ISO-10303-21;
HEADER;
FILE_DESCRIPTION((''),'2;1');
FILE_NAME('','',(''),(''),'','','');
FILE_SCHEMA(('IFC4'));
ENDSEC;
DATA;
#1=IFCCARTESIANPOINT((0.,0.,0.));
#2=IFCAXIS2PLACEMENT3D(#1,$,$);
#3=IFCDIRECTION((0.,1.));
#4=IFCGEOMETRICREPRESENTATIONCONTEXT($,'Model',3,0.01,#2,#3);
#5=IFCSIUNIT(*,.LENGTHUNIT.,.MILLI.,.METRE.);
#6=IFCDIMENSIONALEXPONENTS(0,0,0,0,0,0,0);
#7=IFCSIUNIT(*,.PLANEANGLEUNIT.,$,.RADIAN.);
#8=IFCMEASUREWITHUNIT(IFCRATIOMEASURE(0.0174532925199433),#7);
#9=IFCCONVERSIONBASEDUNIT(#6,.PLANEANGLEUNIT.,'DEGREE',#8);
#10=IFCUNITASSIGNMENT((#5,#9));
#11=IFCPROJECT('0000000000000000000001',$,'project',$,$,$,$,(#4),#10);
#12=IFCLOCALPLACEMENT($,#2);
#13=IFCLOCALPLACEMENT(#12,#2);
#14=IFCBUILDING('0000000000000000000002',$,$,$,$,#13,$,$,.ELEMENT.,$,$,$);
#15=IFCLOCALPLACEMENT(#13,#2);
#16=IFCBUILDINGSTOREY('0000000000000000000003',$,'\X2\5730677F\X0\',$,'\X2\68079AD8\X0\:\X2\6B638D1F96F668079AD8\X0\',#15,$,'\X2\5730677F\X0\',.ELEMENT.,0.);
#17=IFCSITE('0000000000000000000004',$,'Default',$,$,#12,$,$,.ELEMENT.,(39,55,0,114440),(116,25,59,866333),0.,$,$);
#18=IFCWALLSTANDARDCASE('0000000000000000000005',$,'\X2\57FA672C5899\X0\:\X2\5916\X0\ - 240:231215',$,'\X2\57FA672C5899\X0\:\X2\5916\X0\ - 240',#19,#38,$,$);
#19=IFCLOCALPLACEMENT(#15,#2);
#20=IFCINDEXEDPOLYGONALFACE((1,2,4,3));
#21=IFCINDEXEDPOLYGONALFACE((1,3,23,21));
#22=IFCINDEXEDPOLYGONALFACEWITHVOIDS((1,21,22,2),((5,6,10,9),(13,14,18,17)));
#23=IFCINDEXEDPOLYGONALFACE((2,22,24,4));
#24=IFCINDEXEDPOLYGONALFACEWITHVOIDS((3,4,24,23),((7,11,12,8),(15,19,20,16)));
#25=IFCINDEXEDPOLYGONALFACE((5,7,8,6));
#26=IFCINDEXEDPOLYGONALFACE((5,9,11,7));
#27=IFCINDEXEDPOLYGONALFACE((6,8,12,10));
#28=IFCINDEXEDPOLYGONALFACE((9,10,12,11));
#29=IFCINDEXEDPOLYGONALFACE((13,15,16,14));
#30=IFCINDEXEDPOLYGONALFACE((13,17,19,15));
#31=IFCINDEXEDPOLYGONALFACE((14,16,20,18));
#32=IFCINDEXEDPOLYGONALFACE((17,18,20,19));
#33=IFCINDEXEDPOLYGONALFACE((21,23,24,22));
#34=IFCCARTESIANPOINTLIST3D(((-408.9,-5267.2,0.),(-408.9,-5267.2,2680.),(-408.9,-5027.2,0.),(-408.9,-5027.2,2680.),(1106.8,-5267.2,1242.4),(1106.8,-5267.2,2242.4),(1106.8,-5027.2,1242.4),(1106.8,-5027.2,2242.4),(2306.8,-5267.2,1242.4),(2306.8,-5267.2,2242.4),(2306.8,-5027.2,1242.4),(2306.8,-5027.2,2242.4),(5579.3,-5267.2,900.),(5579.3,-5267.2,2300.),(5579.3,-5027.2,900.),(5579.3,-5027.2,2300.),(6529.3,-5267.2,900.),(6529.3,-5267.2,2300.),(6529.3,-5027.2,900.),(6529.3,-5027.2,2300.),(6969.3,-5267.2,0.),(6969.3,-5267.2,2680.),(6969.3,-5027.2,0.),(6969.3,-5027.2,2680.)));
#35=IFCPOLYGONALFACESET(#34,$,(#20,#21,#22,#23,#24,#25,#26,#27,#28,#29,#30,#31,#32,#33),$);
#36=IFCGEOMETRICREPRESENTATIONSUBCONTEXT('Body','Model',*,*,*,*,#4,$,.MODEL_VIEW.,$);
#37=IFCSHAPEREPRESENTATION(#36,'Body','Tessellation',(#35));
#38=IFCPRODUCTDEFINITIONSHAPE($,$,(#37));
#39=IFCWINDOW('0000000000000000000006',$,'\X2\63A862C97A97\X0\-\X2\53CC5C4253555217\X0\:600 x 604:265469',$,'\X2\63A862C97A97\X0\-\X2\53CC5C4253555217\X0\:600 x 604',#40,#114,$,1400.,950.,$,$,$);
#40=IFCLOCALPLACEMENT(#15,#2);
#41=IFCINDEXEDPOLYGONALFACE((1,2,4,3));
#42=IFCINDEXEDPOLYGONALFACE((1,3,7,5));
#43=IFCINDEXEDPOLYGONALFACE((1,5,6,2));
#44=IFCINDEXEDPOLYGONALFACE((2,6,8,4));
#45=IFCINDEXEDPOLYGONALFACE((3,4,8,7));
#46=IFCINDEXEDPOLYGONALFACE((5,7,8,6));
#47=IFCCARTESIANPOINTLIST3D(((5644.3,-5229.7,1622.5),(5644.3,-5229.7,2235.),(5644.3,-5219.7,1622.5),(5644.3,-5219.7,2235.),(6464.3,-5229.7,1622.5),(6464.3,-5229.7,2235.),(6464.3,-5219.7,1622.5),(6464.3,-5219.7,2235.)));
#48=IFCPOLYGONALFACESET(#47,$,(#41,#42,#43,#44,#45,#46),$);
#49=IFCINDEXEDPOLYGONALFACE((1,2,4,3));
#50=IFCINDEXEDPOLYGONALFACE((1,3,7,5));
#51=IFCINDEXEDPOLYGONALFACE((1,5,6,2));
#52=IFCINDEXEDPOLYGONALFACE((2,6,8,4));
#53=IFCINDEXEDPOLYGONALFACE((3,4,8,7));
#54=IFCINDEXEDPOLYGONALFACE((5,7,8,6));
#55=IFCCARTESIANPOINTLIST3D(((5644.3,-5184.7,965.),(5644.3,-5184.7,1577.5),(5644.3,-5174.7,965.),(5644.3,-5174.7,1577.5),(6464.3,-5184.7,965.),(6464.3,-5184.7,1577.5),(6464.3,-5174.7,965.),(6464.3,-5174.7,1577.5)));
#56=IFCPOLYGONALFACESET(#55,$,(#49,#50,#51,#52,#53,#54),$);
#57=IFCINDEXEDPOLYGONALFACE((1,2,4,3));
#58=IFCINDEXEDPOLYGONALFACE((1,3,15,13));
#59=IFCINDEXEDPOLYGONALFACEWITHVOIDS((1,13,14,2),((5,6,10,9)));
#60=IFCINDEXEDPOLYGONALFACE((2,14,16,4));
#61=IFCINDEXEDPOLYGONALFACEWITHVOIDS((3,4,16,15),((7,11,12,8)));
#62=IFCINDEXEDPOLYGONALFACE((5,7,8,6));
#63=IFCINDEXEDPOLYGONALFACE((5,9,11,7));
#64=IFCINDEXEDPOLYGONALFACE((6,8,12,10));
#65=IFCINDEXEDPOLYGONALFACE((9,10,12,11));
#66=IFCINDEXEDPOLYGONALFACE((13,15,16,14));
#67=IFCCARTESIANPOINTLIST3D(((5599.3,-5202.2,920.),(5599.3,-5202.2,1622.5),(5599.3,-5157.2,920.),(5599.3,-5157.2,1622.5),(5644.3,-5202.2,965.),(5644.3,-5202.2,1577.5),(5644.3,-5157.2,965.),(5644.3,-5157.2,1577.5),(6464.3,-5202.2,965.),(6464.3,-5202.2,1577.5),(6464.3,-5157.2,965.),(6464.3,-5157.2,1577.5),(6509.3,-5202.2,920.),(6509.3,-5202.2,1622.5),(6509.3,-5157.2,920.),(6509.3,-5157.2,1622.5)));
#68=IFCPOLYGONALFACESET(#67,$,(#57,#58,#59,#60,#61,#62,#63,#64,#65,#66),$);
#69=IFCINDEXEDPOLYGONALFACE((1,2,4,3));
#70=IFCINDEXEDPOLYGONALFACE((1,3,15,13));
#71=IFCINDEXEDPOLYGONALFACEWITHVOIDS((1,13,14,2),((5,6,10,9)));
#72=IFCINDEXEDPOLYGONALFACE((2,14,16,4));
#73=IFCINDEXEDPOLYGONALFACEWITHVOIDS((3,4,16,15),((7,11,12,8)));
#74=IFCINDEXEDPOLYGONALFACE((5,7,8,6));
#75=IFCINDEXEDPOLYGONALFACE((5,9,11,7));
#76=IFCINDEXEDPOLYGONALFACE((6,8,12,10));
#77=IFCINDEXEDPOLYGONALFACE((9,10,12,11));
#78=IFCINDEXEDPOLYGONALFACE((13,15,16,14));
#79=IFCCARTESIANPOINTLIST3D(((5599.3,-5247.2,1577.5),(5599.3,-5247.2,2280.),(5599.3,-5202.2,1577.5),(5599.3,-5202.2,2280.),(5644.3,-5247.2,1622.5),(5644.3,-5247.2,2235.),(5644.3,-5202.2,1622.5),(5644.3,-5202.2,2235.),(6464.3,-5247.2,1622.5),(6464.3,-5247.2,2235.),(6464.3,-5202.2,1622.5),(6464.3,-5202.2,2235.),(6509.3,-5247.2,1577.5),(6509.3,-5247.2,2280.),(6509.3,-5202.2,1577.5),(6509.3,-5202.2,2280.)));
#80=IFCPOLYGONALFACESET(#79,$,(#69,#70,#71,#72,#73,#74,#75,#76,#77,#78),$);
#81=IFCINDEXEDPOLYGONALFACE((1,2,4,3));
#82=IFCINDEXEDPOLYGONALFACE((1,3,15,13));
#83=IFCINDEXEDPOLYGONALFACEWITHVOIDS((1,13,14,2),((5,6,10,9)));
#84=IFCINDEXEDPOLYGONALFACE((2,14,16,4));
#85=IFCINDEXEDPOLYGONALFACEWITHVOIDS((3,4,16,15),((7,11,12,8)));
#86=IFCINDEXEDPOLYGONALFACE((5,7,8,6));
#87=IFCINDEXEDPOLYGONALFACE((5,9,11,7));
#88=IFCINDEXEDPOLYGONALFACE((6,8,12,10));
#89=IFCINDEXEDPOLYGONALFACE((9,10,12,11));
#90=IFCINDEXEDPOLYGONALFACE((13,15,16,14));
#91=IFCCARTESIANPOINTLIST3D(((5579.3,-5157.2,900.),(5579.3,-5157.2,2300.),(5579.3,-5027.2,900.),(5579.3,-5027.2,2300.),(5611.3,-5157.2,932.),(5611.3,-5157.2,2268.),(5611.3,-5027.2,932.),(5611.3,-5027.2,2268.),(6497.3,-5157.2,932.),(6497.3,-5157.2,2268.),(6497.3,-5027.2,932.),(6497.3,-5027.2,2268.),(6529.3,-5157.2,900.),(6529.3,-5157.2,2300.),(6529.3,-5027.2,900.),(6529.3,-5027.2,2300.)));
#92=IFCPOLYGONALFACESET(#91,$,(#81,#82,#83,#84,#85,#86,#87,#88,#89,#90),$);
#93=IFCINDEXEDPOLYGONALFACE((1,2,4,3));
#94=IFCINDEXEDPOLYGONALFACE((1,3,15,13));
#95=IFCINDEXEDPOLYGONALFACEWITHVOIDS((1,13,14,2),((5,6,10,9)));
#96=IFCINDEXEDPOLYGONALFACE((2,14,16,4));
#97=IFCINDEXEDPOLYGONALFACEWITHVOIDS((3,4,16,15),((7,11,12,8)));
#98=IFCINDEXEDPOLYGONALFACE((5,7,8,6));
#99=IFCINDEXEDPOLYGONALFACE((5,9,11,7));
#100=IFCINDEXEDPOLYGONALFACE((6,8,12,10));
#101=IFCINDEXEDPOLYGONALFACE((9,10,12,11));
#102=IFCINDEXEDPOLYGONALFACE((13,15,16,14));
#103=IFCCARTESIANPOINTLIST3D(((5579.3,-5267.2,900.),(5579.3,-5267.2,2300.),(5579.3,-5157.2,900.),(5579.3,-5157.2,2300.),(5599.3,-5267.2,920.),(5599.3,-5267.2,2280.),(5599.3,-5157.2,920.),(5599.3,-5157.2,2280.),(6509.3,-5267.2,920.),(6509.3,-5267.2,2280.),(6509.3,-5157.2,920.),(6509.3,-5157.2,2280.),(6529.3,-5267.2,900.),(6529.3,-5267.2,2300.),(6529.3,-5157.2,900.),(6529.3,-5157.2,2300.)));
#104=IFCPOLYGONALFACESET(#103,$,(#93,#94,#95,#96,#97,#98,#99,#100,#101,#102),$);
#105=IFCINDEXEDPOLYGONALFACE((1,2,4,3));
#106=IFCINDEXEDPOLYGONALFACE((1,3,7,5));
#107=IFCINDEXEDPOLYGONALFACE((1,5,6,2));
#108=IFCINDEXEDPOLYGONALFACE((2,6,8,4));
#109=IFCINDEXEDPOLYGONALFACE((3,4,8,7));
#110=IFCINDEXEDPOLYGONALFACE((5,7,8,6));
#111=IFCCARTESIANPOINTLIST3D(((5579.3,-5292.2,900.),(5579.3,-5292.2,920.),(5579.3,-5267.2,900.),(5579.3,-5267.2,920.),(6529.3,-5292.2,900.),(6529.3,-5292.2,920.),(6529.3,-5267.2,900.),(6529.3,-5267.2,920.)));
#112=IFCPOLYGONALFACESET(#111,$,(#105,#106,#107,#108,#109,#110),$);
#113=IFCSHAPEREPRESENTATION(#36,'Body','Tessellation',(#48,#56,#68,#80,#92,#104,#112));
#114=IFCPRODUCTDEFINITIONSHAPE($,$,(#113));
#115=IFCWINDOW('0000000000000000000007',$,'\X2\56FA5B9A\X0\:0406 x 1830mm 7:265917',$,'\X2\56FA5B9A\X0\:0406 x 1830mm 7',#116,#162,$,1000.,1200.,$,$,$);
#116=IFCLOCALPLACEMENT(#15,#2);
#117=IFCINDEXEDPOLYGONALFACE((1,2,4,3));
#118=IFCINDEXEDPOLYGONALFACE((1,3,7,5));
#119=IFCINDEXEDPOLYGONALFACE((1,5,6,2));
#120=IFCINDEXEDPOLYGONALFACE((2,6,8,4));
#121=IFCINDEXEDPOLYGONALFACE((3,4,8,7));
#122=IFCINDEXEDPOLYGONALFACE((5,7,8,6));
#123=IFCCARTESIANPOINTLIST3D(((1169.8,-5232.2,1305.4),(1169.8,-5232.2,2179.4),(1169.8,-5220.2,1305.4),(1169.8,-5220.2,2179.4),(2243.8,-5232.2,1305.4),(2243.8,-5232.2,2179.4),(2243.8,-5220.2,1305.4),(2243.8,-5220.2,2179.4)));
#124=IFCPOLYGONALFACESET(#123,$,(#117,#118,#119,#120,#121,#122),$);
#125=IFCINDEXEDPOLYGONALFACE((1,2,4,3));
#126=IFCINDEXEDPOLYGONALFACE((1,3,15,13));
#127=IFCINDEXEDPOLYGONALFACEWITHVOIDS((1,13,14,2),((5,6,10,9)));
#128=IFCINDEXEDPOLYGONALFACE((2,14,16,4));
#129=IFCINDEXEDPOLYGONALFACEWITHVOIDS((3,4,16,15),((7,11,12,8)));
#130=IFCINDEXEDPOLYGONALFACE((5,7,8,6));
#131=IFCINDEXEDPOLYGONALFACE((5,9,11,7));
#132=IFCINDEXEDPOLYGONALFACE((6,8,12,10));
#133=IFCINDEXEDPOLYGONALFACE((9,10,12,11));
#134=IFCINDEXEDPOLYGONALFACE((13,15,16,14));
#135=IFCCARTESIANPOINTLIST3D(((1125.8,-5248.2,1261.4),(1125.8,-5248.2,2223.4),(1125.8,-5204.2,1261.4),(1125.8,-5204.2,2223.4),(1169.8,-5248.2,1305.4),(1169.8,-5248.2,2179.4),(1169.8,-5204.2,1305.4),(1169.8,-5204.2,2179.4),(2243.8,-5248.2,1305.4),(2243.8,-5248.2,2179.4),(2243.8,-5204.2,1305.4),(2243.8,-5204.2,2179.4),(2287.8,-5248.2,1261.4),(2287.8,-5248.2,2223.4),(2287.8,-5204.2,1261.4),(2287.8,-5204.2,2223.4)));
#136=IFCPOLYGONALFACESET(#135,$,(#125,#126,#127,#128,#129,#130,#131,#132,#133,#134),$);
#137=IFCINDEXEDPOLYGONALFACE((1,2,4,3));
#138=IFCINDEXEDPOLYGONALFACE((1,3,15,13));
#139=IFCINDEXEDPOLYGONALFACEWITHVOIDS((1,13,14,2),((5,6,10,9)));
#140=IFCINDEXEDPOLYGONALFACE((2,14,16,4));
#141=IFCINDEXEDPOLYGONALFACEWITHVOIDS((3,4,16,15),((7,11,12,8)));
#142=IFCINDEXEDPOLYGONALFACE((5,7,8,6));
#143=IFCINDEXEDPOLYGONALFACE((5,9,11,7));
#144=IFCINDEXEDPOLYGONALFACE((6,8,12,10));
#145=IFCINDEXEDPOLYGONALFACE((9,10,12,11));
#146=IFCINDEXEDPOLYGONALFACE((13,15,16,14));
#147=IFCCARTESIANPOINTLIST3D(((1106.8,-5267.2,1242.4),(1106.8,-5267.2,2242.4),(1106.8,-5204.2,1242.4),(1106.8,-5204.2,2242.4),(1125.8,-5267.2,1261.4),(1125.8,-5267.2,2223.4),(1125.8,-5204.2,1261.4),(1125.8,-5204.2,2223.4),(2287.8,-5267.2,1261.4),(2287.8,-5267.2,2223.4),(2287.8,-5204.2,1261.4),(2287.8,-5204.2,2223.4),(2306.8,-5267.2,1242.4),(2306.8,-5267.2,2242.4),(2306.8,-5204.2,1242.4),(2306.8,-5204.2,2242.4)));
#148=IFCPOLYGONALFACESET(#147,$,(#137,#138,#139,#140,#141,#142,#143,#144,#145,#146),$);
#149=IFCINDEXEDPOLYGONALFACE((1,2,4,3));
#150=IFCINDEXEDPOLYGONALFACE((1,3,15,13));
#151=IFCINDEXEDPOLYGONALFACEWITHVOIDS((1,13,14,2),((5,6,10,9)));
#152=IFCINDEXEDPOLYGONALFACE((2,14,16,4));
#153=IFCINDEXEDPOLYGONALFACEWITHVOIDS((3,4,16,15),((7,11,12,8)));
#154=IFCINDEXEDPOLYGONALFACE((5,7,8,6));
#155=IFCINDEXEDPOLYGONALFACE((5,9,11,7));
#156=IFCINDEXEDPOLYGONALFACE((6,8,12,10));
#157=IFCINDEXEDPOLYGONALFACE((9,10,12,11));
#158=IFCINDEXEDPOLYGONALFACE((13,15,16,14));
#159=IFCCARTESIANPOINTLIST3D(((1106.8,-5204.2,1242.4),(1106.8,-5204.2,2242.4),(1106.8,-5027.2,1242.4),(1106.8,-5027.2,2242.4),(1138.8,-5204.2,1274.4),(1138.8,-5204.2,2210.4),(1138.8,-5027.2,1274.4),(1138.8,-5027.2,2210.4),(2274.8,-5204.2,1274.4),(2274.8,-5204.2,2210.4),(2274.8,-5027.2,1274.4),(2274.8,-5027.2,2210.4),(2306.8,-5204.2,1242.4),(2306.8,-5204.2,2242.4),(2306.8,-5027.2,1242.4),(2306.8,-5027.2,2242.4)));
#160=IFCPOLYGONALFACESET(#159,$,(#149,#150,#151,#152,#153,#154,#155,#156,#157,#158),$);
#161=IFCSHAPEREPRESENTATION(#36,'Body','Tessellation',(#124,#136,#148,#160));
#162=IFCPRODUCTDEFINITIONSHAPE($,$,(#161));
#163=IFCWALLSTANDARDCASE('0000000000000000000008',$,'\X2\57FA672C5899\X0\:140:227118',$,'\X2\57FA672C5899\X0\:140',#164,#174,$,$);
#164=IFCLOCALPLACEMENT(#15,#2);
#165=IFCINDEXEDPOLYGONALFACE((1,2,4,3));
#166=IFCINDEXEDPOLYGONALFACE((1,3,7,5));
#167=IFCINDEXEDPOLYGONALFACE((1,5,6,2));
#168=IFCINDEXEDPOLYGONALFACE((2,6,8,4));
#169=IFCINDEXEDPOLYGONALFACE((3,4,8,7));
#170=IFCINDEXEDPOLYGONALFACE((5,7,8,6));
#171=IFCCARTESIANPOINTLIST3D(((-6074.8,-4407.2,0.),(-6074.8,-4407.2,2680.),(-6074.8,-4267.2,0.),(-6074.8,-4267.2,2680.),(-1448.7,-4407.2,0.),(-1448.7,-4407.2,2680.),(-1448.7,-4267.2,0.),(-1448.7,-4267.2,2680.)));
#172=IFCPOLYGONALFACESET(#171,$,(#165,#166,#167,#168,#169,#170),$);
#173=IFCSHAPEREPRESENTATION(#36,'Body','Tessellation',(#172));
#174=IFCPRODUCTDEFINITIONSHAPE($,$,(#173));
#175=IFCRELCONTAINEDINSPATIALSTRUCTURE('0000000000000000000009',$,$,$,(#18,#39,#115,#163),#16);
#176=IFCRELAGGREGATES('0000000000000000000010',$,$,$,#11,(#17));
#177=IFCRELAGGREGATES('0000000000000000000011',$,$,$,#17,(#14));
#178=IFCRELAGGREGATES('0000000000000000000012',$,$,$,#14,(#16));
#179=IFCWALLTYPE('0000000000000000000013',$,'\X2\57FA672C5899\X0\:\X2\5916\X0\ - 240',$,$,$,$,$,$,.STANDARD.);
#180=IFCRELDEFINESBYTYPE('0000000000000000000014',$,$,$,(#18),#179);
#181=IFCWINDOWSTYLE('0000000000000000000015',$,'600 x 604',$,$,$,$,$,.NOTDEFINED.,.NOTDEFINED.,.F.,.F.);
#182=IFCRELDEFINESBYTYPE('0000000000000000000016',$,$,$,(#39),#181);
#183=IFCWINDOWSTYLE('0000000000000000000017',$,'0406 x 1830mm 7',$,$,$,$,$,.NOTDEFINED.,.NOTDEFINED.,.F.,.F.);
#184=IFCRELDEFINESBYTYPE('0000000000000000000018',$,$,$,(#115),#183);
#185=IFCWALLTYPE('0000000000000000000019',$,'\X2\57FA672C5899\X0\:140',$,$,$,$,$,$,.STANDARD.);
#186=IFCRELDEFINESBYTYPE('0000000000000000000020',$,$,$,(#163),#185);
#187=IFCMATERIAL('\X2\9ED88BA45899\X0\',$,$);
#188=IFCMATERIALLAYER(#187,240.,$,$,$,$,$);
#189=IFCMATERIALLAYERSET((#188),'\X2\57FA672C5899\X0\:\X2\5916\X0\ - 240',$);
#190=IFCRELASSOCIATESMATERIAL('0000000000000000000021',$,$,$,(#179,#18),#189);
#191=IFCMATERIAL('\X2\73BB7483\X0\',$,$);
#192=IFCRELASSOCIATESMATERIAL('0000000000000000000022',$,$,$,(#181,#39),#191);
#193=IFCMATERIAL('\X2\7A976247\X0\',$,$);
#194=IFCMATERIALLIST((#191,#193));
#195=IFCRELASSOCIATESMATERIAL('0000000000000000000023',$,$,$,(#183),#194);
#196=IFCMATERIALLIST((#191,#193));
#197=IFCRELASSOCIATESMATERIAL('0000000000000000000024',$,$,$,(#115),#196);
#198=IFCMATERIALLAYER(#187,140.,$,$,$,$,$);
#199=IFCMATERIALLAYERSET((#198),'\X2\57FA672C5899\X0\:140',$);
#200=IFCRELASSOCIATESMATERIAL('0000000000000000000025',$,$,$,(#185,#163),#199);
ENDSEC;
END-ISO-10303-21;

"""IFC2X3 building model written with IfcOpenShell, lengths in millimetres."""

from ifc_helpers import new_model, entity, si_unit, converted_unit, direction, frame, frame_2d, origin, origin_2d_with_axis, place, context, subcontext, project, spatial, polyline, rectangle, outline, extrude, source, transform, mapped, material, material_list, layer, layer_set, layer_usage, type_object, type_shapes, element, fill, save


model = new_model("IFC2X3")

# Units and contexts
model_context = context("Model", 3, precision=0.01, world=origin(), true_north=direction((0.0, 1.0)))
body_context = subcontext(model_context, "Body", "Model", "MODEL_VIEW")
ifc_project = project(units=[si_unit("LENGTHUNIT", "METRE", prefix="MILLI"), converted_unit("PLANEANGLEUNIT", "DEGREE", entity("IfcRatioMeasure", 0.0174532925199433), si_unit("PLANEANGLEUNIT", "RADIAN"), dimensions=[0, 0, 0, 0, 0, 0, 0])], contexts=[model_context])

# Site, building, storey
site_placement = place(None, origin())
site = spatial("IfcSite", under=ifc_project, at=site_placement, Name="Default", CompositionType="ELEMENT", RefLatitude=(39, 55, 0, 114440), RefLongitude=(116, 25, 59, 866333), RefElevation=0.0)
building_placement = place(site_placement, origin())
building = spatial("IfcBuilding", under=site, at=building_placement, CompositionType="ELEMENT")
storey_placement = place(building_placement, origin())
storey = spatial("IfcBuildingStorey", under=building, at=storey_placement, Name="地板", ObjectType="标高:正负零标高", LongName="地板", CompositionType="ELEMENT", Elevation=0.0)

# Shared definitions
ifc_material_1 = material(Name="默认墙")

# Shared definitions
ifc_layer_1 = layer(ifc_material_1, 240.0)
ifc_layer_set_1 = layer_set([ifc_layer_1], Name="基本墙:外 - 240")
wall_type_1 = type_object("IfcWallType", Name="基本墙:外 - 240", PredefinedType="STANDARD", material=ifc_layer_set_1)

# Wall, openings, windows
ifc_material_2 = material(Name="玻璃")
window_style_1 = type_object("IfcWindowStyle", Name="600 x 604", ConstructionType="NOTDEFINED", OperationType="NOTDEFINED", ParameterTakesPrecedence=False, Sizeable=False, material=ifc_material_2)
shared_shape_1 = source(origin(), body_context, "Body", "SweptSolid", [
    extrude(rectangle(XDim=10.0, YDim=820.0, at=origin_2d_with_axis()), frame((475.0, 197.5, 722.5), z_axis=(0.0, 0.0, 1.0), x_axis=(0.0, -1.0, 0.0)), (0.0, 0.0, 1.0), 612.5),
    extrude(rectangle(XDim=10.0, YDim=820.0, at=origin_2d_with_axis()), frame((475.0, 152.5, 65.0), z_axis=(0.0, 0.0, 1.0), x_axis=(0.0, -1.0, 0.0)), (0.0, 0.0, 1.0), 612.5),
    extrude(outline(polyline([(-455.0, -351.2), (455.0, -351.2), (455.0, 351.2), (-455.0, 351.2), (-455.0, -351.2)]), holes=[polyline([(-410.0, -306.2), (-410.0, 306.2), (410.0, 306.2), (410.0, -306.2), (-410.0, -306.2)])]), frame((475.0, 130.0, 371.3), z_axis=(0.0, 1.0, 0.0), x_axis=(1.0, 0.0, 0.0)), (0.0, 0.0, 1.0), 45.0),
    extrude(outline(polyline([(-455.0, -351.2), (455.0, -351.2), (455.0, 351.2), (-455.0, 351.2), (-455.0, -351.2)]), holes=[polyline([(-410.0, -306.2), (-410.0, 306.2), (410.0, 306.2), (410.0, -306.2), (-410.0, -306.2)])]), frame((475.0, 175.0, 1028.8), z_axis=(0.0, 1.0, 0.0), x_axis=(1.0, 0.0, 0.0)), (0.0, 0.0, 1.0), 45.0),
    extrude(outline(polyline([(-475.0, -700.0), (475.0, -700.0), (475.0, 700.0), (-475.0, 700.0), (-475.0, -700.0)]), holes=[polyline([(-443.0, -668.0), (-443.0, 668.0), (443.0, 668.0), (443.0, -668.0), (-443.0, -668.0)])]), frame((475.0, 0.0, 700.0), z_axis=(0.0, 1.0, 0.0), x_axis=(1.0, 0.0, 0.0)), (0.0, 0.0, 1.0), 130.0),
    extrude(outline(polyline([(-700.0, -475.0), (700.0, -475.0), (700.0, 475.0), (-700.0, 475.0), (-700.0, -475.0)]), holes=[polyline([(-680.0, -455.0), (-680.0, 455.0), (680.0, 455.0), (680.0, -455.0), (-680.0, -455.0)])]), frame((475.0, 130.0, 700.0), z_axis=(0.0, 1.0, 0.0), x_axis=(0.0, 0.0, -1.0)), (0.0, 0.0, 1.0), 110.0),
    extrude(rectangle(XDim=25.0, YDim=950.0, at=origin_2d_with_axis()), frame((475.0, 252.5, 0.0), z_axis=(0.0, 0.0, 1.0), x_axis=(0.0, -1.0, 0.0)), (0.0, 0.0, 1.0), 20.0),
])
type_shapes(window_style_1, [shared_shape_1])
ifc_layer_usage_1 = layer_usage(ifc_layer_set_1, "AXIS2", "NEGATIVE", 120.0)
wall_1_placement = place(storey_placement, frame((-408.9, -5147.2, 0.0)))
wall_1 = element("IfcWallStandardCase", 1, at=wall_1_placement, inside=storey, type_object=wall_type_1, material=ifc_layer_usage_1, Name="基本墙:外 - 240:231215", ObjectType="基本墙:外 - 240", context=body_context, shape_type="SweptSolid", body=[
    extrude(rectangle(XDim=7378.2, YDim=240.0, at=frame_2d((3689.1, 0.0), x_axis=(-1.0, 0.0))), origin(), (0.0, 0.0, 1.0), 2680.0),
])
opening_1_placement = place(wall_1_placement, frame((6938.2, 120.0, 900.0)))
opening_1 = element("IfcOpeningElement", 2, at=opening_1_placement, cuts=wall_1, ObjectType="Opening", context=body_context, shape_type="SweptSolid", body=[
    extrude(rectangle(XDim=1400.0, YDim=950.0, at=frame_2d((700.0, 475.0), x_axis=(-1.0, 0.0))), frame((0.0, 0.0, 0.0), z_axis=(0.0, -1.0, 0.0), x_axis=(0.0, 0.0, 1.0)), (0.0, 0.0, 1.0), 240.0),
])
opening_2_placement = place(wall_1_placement, frame((2715.8, 120.0, 1242.4)))
opening_2 = element("IfcOpeningElement", 3, at=opening_2_placement, cuts=wall_1, ObjectType="Opening", context=body_context, shape_type="SweptSolid", body=[
    extrude(rectangle(XDim=1000.0, YDim=1200.0, at=frame_2d((500.0, 600.0), x_axis=(1.0, 0.0))), frame((0.0, 0.0, 0.0), z_axis=(0.0, -1.0, 0.0), x_axis=(0.0, 0.0, 1.0)), (0.0, 0.0, 1.0), 240.0),
])
window_1_placement = place(opening_1_placement, frame((0.0, 0.0, 0.0), z_axis=(0.0, 0.0, 1.0), x_axis=(-1.0, 0.0, 0.0)))
window_1 = element("IfcWindow", 4, at=window_1_placement, inside=storey, type_object=window_style_1, material=ifc_material_2, Name="推拉窗-双层单列:600 x 604:265469", ObjectType="推拉窗-双层单列:600 x 604", OverallHeight=1400.0, OverallWidth=950.0, context=body_context, shape_type="MappedRepresentation", body=[
    mapped(shared_shape_1, transform((0.0, 0.0, 0.0), scale=1.0)),
])
fill(opening_1, window_1)
ifc_material_3 = material(Name="窗扇")
ifc_material_list_1 = material_list([ifc_material_2, ifc_material_3])
ifc_material_list_2 = material_list([ifc_material_2, ifc_material_3])
window_style_2 = type_object("IfcWindowStyle", Name="0406 x 1830mm 7", ConstructionType="NOTDEFINED", OperationType="NOTDEFINED", ParameterTakesPrecedence=False, Sizeable=False, material=ifc_material_list_2)
shared_shape_2 = source(origin(), body_context, "Body", "SweptSolid", [
    extrude(rectangle(XDim=12.0, YDim=1074.0, at=frame_2d((0.0, 0.0), x_axis=(1.0, 0.0))), frame((600.0, 199.0, 63.0), z_axis=(0.0, 0.0, 1.0), x_axis=(0.0, -1.0, 0.0)), (0.0, 0.0, 1.0), 874.0),
    extrude(outline(polyline([(-581.0, -481.0), (581.0, -481.0), (581.0, 481.0), (-581.0, 481.0), (-581.0, -481.0)]), holes=[polyline([(-537.0, -437.0), (-537.0, 437.0), (537.0, 437.0), (537.0, -437.0), (-537.0, -437.0)])]), frame((600.0, 177.0, 500.0), z_axis=(0.0, 1.0, 0.0), x_axis=(1.0, 0.0, 0.0)), (0.0, 0.0, 1.0), 44.0),
    extrude(outline(polyline([(-600.0, -500.0), (600.0, -500.0), (600.0, 500.0), (-600.0, 500.0), (-600.0, -500.0)]), holes=[polyline([(-581.0, -481.0), (-581.0, 481.0), (581.0, 481.0), (581.0, -481.0), (-581.0, -481.0)])]), frame((600.0, 177.0, 500.0), z_axis=(0.0, 1.0, 0.0), x_axis=(1.0, 0.0, 0.0)), (0.0, 0.0, 1.0), 63.0),
    extrude(outline(polyline([(-600.0, -500.0), (600.0, -500.0), (600.0, 500.0), (-600.0, 500.0), (-600.0, -500.0)]), holes=[polyline([(-568.0, -468.0), (-568.0, 468.0), (568.0, 468.0), (568.0, -468.0), (-568.0, -468.0)])]), frame((600.0, 0.0, 500.0), z_axis=(0.0, 1.0, 0.0), x_axis=(1.0, 0.0, 0.0)), (0.0, 0.0, 1.0), 177.0),
])
type_shapes(window_style_2, [shared_shape_2])
window_2_placement = place(opening_2_placement, frame((0.0, 0.0, 0.0), z_axis=(0.0, 0.0, 1.0), x_axis=(-1.0, 0.0, 0.0)))
window_2 = element("IfcWindow", 5, at=window_2_placement, inside=storey, type_object=window_style_2, material=ifc_material_list_1, Name="固定:0406 x 1830mm 7:265917", ObjectType="固定:0406 x 1830mm 7", OverallHeight=1000.0, OverallWidth=1200.0, context=body_context, shape_type="MappedRepresentation", body=[
    mapped(shared_shape_2, transform((0.0, 0.0, 0.0), scale=1.0)),
])
fill(opening_2, window_2)

# Wall
ifc_layer_2 = layer(ifc_material_1, 140.0)
ifc_layer_set_2 = layer_set([ifc_layer_2], Name="基本墙:140")
ifc_layer_usage_2 = layer_usage(ifc_layer_set_2, "AXIS2", "NEGATIVE", 70.0)
wall_type_2 = type_object("IfcWallType", Name="基本墙:140", PredefinedType="STANDARD", material=ifc_layer_set_2)
wall_2_placement = place(storey_placement, frame((-1448.7, -4337.2, 0.0), z_axis=(0.0, 0.0, 1.0), x_axis=(-1.0, 0.0, 0.0)))
element("IfcWallStandardCase", 6, at=wall_2_placement, inside=storey, type_object=wall_type_2, material=ifc_layer_usage_2, Name="基本墙:140:227118", ObjectType="基本墙:140", context=body_context, shape_type="SweptSolid", body=[
    extrude(rectangle(XDim=4626.1, YDim=140.0, at=frame_2d((2313.1, 0.0), x_axis=(-1.0, 0.0))), origin(), (0.0, 0.0, 1.0), 2680.0),
])

save(model, "model.ifc")
